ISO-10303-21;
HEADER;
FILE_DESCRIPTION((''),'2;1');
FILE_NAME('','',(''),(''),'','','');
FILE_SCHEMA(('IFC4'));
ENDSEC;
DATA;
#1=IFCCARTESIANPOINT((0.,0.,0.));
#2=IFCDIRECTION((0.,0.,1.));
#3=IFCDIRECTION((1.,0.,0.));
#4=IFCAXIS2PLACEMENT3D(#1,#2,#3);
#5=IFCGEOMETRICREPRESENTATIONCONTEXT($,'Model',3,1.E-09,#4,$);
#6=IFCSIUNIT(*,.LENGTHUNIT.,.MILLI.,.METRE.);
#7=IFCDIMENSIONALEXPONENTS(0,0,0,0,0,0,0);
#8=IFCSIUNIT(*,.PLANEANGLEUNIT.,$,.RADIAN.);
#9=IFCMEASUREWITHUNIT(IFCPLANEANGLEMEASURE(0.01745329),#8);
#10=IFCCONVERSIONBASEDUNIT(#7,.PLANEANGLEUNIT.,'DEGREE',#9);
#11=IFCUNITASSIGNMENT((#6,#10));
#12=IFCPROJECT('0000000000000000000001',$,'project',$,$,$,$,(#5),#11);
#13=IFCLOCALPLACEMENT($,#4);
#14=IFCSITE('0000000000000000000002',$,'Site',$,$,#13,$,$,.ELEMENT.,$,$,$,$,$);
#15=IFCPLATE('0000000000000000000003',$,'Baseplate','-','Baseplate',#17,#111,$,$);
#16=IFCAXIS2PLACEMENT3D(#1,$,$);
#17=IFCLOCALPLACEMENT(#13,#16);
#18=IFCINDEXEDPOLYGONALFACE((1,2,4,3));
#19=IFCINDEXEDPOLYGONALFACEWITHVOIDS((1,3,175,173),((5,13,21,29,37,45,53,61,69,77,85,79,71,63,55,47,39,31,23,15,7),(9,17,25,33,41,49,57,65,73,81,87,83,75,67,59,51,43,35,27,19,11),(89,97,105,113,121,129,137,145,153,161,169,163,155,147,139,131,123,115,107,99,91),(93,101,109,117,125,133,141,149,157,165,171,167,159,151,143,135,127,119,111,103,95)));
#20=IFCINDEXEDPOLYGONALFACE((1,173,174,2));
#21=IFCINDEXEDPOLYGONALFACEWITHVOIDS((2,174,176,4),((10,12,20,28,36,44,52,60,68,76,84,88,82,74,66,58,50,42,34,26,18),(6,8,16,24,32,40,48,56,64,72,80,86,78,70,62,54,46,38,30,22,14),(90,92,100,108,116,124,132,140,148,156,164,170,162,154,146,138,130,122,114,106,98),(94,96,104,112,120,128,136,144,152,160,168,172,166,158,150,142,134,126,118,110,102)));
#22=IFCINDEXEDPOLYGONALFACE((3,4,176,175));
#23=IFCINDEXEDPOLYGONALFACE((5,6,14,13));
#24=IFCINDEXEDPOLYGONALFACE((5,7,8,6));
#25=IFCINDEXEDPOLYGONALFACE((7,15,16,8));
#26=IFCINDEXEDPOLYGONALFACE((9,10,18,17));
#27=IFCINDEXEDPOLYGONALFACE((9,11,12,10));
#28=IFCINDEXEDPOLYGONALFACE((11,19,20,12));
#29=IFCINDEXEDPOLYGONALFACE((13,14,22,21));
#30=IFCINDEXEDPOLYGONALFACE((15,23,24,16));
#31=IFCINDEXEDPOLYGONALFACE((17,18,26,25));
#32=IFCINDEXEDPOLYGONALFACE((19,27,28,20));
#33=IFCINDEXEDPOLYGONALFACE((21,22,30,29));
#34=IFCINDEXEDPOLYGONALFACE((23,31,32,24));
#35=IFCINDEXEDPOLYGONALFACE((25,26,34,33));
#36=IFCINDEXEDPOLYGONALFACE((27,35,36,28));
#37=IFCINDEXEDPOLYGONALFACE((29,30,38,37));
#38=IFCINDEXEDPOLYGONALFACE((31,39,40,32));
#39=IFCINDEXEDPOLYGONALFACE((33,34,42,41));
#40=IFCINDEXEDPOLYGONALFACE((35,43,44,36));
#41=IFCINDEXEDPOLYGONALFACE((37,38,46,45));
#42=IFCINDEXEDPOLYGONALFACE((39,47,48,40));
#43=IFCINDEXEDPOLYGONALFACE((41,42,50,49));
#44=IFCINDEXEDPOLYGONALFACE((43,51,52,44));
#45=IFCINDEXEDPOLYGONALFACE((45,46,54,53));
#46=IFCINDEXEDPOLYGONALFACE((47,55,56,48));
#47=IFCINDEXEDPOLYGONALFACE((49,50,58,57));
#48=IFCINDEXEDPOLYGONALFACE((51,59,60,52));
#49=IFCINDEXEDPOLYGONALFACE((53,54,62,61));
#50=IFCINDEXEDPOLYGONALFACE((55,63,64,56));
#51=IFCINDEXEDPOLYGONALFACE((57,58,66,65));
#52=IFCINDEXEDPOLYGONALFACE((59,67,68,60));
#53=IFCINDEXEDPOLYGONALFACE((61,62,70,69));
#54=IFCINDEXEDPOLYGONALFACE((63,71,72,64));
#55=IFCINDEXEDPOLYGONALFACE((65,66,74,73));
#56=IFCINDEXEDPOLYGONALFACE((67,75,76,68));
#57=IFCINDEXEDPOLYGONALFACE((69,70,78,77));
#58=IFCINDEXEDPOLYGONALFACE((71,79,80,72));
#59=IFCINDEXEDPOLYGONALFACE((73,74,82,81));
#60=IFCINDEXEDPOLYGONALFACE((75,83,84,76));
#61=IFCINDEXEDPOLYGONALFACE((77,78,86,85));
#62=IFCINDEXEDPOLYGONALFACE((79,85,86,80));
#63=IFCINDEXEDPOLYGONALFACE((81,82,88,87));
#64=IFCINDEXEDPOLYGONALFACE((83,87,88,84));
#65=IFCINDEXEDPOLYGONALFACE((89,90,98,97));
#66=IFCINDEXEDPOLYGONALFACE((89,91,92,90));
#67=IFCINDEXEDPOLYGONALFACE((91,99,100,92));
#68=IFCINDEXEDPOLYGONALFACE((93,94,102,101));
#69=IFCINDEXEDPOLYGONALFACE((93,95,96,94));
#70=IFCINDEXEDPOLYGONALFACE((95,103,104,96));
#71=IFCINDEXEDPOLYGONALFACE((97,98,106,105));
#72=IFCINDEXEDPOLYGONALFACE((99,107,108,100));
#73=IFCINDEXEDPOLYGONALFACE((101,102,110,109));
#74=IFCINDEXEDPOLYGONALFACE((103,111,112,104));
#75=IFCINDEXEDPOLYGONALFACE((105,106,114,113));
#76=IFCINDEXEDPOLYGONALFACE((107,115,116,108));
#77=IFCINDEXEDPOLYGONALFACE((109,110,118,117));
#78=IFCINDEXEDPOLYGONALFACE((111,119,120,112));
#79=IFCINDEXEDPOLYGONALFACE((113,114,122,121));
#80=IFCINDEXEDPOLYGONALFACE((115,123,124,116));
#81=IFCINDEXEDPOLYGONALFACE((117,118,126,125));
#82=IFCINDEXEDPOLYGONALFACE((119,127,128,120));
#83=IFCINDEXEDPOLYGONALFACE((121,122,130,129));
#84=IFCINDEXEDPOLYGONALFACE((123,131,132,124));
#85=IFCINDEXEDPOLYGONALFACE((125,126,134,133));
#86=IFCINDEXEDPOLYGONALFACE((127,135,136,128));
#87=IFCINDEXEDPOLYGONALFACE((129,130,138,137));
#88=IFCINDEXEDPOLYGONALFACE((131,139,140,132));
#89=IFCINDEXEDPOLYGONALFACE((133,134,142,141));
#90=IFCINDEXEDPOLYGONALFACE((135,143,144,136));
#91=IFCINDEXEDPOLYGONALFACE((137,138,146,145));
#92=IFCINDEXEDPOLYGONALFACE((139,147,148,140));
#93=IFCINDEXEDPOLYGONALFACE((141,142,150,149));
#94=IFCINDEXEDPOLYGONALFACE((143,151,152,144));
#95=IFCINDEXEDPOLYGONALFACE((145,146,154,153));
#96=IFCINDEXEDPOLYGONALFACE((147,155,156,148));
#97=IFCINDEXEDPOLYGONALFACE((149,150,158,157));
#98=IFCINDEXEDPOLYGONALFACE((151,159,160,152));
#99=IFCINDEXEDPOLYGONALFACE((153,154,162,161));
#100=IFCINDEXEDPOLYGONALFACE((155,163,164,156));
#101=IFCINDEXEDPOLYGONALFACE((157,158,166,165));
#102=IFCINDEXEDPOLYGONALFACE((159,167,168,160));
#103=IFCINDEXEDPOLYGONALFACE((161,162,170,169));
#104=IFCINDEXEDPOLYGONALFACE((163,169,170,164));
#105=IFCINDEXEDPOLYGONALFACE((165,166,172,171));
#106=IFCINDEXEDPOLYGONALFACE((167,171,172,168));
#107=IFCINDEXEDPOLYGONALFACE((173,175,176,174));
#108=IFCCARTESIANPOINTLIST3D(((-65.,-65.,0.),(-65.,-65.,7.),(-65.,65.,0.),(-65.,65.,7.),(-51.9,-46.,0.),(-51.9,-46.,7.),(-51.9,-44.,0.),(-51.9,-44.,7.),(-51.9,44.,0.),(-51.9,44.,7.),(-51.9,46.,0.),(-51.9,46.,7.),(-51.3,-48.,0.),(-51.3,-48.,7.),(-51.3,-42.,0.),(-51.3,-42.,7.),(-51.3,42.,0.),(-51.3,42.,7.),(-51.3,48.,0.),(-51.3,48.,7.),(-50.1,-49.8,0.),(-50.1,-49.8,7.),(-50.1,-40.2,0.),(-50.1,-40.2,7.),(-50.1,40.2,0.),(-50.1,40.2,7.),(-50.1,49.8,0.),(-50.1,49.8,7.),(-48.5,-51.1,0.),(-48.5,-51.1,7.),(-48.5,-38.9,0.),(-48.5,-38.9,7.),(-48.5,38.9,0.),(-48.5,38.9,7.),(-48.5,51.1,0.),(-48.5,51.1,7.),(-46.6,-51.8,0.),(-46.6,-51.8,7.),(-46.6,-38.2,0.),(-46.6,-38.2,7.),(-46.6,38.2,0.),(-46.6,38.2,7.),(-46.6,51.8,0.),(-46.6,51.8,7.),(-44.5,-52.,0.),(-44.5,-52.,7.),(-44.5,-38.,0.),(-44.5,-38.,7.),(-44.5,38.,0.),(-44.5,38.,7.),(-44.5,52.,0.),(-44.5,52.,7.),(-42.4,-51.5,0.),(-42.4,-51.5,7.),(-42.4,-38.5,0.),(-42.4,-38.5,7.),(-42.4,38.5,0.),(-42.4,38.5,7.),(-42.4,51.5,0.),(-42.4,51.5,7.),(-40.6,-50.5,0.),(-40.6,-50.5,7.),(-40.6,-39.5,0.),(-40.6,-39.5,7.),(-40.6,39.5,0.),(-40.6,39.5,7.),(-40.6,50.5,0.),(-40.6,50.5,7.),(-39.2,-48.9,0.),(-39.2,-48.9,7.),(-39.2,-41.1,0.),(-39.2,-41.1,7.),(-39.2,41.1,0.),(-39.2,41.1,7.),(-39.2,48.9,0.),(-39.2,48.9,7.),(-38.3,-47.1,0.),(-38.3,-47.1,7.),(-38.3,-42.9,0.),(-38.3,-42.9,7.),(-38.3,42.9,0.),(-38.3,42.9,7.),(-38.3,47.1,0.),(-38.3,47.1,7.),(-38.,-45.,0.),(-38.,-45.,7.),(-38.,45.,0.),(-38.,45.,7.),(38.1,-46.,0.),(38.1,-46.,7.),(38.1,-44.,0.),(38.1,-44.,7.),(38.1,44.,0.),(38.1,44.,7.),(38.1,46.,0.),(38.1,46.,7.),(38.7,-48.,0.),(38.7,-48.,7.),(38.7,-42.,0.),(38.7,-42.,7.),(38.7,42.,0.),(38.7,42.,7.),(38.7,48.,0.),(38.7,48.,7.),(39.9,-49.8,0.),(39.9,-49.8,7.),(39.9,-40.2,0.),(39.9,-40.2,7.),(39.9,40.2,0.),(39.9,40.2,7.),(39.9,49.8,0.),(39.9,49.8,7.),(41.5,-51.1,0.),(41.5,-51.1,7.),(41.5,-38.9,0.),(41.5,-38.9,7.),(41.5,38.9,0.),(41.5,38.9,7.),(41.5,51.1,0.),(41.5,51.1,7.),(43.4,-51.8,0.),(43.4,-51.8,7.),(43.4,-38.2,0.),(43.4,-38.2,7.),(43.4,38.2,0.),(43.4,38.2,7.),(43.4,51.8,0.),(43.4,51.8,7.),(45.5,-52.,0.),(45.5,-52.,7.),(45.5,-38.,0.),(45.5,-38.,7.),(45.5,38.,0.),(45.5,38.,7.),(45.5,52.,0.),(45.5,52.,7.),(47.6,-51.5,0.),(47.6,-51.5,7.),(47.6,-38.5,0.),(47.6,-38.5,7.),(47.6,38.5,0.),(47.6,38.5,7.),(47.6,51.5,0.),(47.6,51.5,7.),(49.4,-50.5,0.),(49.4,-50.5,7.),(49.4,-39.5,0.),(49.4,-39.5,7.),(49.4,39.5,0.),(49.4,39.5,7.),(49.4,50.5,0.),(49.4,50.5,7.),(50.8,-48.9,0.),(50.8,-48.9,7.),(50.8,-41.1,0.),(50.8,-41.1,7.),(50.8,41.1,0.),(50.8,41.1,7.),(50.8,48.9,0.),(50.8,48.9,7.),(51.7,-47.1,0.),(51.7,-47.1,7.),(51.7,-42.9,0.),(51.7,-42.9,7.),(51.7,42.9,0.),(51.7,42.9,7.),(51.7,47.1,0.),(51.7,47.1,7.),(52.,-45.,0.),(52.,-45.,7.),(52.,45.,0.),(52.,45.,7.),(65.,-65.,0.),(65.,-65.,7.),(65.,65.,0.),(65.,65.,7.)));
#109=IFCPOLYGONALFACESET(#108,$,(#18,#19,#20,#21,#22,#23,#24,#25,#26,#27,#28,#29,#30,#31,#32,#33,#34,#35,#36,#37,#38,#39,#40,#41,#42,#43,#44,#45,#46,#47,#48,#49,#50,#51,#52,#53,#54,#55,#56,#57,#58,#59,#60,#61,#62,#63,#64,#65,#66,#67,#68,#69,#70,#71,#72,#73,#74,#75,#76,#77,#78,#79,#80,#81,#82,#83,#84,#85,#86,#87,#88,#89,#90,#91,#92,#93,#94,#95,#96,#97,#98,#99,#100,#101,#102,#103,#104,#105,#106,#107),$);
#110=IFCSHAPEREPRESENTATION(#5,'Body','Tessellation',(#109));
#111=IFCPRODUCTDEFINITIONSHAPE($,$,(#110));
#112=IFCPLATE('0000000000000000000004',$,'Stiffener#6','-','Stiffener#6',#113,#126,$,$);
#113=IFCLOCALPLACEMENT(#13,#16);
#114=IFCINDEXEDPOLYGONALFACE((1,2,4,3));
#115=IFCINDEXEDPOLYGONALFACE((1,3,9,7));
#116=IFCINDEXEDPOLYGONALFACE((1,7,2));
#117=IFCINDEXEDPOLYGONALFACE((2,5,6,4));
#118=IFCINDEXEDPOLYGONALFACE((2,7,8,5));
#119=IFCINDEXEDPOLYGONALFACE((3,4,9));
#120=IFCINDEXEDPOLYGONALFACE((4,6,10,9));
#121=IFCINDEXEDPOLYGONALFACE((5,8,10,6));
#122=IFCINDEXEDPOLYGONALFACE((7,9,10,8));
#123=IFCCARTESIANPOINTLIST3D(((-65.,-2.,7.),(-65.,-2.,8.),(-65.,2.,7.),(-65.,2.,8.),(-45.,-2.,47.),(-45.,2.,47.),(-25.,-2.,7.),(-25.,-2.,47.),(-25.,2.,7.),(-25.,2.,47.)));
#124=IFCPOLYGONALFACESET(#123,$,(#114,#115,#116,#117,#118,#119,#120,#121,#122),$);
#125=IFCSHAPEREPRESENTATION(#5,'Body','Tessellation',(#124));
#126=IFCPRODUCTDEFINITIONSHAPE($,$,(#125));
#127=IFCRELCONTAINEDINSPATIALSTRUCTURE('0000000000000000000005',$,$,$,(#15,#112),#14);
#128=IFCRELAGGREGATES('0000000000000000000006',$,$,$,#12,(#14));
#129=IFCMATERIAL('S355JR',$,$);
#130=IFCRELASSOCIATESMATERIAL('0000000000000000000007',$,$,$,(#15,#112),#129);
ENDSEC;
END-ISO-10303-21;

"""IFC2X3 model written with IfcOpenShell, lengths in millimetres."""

from ifc_helpers import new_model, entity, si_unit, converted_unit, frame, frame_2d, origin, origin_with_axes, place, context, project, spatial, polyline, circle, outline, extrude, material, element, save


model = new_model("IFC2X3")

# Units and contexts
model_context = context("Model", 3, precision=1e-09, world=origin_with_axes())
ifc_project = project(units=[si_unit("LENGTHUNIT", "METRE", prefix="MILLI"), converted_unit("PLANEANGLEUNIT", "DEGREE", entity("IfcPlaneAngleMeasure", 0.01745329), si_unit("PLANEANGLEUNIT", "RADIAN"), dimensions=[0, 0, 0, 0, 0, 0, 0])], contexts=[model_context])

# Site
site_placement = place(None, origin_with_axes())
site = spatial("IfcSite", under=ifc_project, at=site_placement, Name="Site", CompositionType="ELEMENT")

# Shared definitions
ifc_material = material(Name="S355JR")

# Plate, openings
plate_1_placement = place(None, frame((-65.0, 65.0, 7.0), z_axis=(0.0, 0.0, -1.0), x_axis=(1.0, 0.0, 0.0)))
plate_1 = element("IfcPlate", 1, at=plate_1_placement, inside=site, material=ifc_material, Name="Baseplate", Description="-", ObjectType="Baseplate", context=model_context, shape_type="SweptSolid", body=[
    extrude(outline(polyline([(0.0, 0.0), (130.0, 0.0), (130.0, 130.0), (0.0, 130.0), (0.0, 0.0)])), origin_with_axes(), (0.0, 0.0, 1.0), 7.0),
])
opening_1_placement = place(plate_1_placement, frame((20.0, 65.0, 7.5), z_axis=(0.0, 0.0, -1.0), x_axis=(1.0, 0.0, 0.0)))
element("IfcOpeningElement", 2, at=opening_1_placement, cuts=plate_1, ObjectType="Opening", context=model_context, shape_type="SweptSolid", body=[
    extrude(circle(Radius=7.0, at=frame_2d((0.0, 45.0), x_axis=(1.0, 0.0))), origin(), (0.0, 0.0, 1.0), 8.0),
])
opening_2_placement = place(plate_1_placement, frame((20.0, 65.0, 7.5), z_axis=(0.0, 0.0, -1.0), x_axis=(1.0, 0.0, 0.0)))
element("IfcOpeningElement", 3, at=opening_2_placement, cuts=plate_1, ObjectType="Opening", context=model_context, shape_type="SweptSolid", body=[
    extrude(circle(Radius=7.0, at=frame_2d((0.0, -45.0), x_axis=(1.0, 0.0))), origin(), (0.0, 0.0, 1.0), 8.0),
])
opening_3_placement = place(plate_1_placement, frame((110.0, 65.0, 7.5), z_axis=(0.0, 0.0, -1.0), x_axis=(1.0, 0.0, 0.0)))
element("IfcOpeningElement", 4, at=opening_3_placement, cuts=plate_1, ObjectType="Opening", context=model_context, shape_type="SweptSolid", body=[
    extrude(circle(Radius=7.0, at=frame_2d((0.0, 45.0), x_axis=(1.0, 0.0))), origin(), (0.0, 0.0, 1.0), 8.0),
])
opening_4_placement = place(plate_1_placement, frame((110.0, 65.0, 7.5), z_axis=(0.0, 0.0, -1.0), x_axis=(1.0, 0.0, 0.0)))
element("IfcOpeningElement", 5, at=opening_4_placement, cuts=plate_1, ObjectType="Opening", context=model_context, shape_type="SweptSolid", body=[
    extrude(circle(Radius=7.0, at=frame_2d((0.0, -45.0), x_axis=(1.0, 0.0))), origin(), (0.0, 0.0, 1.0), 8.0),
])

# Plate, opening
plate_2_placement = place(None, frame((-25.0, -2.0, 7.0), z_axis=(0.0, 1.0, 0.0), x_axis=(-1.0, 0.0, 0.0)))
plate_2 = element("IfcPlate", 6, at=plate_2_placement, inside=site, material=ifc_material, Name="Stiffener#6", Description="-", ObjectType="Stiffener#6", context=model_context, shape_type="SweptSolid", body=[
    extrude(outline(polyline([(0.0, 0.0), (40.0, 0.0), (40.0, 40.0), (0.0, 40.0), (0.0, 0.0)])), origin_with_axes(), (0.0, 0.0, 1.0), 4.0),
])
opening_5_placement = place(plate_2_placement, frame((0.0, 0.0, 0.0), z_axis=(0.0, 0.0, 1.0), x_axis=(1.0, 0.0, 0.0)))
element("IfcOpeningElement", 7, at=opening_5_placement, cuts=plate_2, ObjectType="Opening", context=model_context, shape_type="SweptSolid", body=[
    extrude(outline(polyline([(40.0, 40.0), (20.0, 40.0), (40.0, 1.0), (40.0, 40.0)])), origin(), (0.0, 0.0, 1.0), 4.0),
])

save(model, "model.ifc")
